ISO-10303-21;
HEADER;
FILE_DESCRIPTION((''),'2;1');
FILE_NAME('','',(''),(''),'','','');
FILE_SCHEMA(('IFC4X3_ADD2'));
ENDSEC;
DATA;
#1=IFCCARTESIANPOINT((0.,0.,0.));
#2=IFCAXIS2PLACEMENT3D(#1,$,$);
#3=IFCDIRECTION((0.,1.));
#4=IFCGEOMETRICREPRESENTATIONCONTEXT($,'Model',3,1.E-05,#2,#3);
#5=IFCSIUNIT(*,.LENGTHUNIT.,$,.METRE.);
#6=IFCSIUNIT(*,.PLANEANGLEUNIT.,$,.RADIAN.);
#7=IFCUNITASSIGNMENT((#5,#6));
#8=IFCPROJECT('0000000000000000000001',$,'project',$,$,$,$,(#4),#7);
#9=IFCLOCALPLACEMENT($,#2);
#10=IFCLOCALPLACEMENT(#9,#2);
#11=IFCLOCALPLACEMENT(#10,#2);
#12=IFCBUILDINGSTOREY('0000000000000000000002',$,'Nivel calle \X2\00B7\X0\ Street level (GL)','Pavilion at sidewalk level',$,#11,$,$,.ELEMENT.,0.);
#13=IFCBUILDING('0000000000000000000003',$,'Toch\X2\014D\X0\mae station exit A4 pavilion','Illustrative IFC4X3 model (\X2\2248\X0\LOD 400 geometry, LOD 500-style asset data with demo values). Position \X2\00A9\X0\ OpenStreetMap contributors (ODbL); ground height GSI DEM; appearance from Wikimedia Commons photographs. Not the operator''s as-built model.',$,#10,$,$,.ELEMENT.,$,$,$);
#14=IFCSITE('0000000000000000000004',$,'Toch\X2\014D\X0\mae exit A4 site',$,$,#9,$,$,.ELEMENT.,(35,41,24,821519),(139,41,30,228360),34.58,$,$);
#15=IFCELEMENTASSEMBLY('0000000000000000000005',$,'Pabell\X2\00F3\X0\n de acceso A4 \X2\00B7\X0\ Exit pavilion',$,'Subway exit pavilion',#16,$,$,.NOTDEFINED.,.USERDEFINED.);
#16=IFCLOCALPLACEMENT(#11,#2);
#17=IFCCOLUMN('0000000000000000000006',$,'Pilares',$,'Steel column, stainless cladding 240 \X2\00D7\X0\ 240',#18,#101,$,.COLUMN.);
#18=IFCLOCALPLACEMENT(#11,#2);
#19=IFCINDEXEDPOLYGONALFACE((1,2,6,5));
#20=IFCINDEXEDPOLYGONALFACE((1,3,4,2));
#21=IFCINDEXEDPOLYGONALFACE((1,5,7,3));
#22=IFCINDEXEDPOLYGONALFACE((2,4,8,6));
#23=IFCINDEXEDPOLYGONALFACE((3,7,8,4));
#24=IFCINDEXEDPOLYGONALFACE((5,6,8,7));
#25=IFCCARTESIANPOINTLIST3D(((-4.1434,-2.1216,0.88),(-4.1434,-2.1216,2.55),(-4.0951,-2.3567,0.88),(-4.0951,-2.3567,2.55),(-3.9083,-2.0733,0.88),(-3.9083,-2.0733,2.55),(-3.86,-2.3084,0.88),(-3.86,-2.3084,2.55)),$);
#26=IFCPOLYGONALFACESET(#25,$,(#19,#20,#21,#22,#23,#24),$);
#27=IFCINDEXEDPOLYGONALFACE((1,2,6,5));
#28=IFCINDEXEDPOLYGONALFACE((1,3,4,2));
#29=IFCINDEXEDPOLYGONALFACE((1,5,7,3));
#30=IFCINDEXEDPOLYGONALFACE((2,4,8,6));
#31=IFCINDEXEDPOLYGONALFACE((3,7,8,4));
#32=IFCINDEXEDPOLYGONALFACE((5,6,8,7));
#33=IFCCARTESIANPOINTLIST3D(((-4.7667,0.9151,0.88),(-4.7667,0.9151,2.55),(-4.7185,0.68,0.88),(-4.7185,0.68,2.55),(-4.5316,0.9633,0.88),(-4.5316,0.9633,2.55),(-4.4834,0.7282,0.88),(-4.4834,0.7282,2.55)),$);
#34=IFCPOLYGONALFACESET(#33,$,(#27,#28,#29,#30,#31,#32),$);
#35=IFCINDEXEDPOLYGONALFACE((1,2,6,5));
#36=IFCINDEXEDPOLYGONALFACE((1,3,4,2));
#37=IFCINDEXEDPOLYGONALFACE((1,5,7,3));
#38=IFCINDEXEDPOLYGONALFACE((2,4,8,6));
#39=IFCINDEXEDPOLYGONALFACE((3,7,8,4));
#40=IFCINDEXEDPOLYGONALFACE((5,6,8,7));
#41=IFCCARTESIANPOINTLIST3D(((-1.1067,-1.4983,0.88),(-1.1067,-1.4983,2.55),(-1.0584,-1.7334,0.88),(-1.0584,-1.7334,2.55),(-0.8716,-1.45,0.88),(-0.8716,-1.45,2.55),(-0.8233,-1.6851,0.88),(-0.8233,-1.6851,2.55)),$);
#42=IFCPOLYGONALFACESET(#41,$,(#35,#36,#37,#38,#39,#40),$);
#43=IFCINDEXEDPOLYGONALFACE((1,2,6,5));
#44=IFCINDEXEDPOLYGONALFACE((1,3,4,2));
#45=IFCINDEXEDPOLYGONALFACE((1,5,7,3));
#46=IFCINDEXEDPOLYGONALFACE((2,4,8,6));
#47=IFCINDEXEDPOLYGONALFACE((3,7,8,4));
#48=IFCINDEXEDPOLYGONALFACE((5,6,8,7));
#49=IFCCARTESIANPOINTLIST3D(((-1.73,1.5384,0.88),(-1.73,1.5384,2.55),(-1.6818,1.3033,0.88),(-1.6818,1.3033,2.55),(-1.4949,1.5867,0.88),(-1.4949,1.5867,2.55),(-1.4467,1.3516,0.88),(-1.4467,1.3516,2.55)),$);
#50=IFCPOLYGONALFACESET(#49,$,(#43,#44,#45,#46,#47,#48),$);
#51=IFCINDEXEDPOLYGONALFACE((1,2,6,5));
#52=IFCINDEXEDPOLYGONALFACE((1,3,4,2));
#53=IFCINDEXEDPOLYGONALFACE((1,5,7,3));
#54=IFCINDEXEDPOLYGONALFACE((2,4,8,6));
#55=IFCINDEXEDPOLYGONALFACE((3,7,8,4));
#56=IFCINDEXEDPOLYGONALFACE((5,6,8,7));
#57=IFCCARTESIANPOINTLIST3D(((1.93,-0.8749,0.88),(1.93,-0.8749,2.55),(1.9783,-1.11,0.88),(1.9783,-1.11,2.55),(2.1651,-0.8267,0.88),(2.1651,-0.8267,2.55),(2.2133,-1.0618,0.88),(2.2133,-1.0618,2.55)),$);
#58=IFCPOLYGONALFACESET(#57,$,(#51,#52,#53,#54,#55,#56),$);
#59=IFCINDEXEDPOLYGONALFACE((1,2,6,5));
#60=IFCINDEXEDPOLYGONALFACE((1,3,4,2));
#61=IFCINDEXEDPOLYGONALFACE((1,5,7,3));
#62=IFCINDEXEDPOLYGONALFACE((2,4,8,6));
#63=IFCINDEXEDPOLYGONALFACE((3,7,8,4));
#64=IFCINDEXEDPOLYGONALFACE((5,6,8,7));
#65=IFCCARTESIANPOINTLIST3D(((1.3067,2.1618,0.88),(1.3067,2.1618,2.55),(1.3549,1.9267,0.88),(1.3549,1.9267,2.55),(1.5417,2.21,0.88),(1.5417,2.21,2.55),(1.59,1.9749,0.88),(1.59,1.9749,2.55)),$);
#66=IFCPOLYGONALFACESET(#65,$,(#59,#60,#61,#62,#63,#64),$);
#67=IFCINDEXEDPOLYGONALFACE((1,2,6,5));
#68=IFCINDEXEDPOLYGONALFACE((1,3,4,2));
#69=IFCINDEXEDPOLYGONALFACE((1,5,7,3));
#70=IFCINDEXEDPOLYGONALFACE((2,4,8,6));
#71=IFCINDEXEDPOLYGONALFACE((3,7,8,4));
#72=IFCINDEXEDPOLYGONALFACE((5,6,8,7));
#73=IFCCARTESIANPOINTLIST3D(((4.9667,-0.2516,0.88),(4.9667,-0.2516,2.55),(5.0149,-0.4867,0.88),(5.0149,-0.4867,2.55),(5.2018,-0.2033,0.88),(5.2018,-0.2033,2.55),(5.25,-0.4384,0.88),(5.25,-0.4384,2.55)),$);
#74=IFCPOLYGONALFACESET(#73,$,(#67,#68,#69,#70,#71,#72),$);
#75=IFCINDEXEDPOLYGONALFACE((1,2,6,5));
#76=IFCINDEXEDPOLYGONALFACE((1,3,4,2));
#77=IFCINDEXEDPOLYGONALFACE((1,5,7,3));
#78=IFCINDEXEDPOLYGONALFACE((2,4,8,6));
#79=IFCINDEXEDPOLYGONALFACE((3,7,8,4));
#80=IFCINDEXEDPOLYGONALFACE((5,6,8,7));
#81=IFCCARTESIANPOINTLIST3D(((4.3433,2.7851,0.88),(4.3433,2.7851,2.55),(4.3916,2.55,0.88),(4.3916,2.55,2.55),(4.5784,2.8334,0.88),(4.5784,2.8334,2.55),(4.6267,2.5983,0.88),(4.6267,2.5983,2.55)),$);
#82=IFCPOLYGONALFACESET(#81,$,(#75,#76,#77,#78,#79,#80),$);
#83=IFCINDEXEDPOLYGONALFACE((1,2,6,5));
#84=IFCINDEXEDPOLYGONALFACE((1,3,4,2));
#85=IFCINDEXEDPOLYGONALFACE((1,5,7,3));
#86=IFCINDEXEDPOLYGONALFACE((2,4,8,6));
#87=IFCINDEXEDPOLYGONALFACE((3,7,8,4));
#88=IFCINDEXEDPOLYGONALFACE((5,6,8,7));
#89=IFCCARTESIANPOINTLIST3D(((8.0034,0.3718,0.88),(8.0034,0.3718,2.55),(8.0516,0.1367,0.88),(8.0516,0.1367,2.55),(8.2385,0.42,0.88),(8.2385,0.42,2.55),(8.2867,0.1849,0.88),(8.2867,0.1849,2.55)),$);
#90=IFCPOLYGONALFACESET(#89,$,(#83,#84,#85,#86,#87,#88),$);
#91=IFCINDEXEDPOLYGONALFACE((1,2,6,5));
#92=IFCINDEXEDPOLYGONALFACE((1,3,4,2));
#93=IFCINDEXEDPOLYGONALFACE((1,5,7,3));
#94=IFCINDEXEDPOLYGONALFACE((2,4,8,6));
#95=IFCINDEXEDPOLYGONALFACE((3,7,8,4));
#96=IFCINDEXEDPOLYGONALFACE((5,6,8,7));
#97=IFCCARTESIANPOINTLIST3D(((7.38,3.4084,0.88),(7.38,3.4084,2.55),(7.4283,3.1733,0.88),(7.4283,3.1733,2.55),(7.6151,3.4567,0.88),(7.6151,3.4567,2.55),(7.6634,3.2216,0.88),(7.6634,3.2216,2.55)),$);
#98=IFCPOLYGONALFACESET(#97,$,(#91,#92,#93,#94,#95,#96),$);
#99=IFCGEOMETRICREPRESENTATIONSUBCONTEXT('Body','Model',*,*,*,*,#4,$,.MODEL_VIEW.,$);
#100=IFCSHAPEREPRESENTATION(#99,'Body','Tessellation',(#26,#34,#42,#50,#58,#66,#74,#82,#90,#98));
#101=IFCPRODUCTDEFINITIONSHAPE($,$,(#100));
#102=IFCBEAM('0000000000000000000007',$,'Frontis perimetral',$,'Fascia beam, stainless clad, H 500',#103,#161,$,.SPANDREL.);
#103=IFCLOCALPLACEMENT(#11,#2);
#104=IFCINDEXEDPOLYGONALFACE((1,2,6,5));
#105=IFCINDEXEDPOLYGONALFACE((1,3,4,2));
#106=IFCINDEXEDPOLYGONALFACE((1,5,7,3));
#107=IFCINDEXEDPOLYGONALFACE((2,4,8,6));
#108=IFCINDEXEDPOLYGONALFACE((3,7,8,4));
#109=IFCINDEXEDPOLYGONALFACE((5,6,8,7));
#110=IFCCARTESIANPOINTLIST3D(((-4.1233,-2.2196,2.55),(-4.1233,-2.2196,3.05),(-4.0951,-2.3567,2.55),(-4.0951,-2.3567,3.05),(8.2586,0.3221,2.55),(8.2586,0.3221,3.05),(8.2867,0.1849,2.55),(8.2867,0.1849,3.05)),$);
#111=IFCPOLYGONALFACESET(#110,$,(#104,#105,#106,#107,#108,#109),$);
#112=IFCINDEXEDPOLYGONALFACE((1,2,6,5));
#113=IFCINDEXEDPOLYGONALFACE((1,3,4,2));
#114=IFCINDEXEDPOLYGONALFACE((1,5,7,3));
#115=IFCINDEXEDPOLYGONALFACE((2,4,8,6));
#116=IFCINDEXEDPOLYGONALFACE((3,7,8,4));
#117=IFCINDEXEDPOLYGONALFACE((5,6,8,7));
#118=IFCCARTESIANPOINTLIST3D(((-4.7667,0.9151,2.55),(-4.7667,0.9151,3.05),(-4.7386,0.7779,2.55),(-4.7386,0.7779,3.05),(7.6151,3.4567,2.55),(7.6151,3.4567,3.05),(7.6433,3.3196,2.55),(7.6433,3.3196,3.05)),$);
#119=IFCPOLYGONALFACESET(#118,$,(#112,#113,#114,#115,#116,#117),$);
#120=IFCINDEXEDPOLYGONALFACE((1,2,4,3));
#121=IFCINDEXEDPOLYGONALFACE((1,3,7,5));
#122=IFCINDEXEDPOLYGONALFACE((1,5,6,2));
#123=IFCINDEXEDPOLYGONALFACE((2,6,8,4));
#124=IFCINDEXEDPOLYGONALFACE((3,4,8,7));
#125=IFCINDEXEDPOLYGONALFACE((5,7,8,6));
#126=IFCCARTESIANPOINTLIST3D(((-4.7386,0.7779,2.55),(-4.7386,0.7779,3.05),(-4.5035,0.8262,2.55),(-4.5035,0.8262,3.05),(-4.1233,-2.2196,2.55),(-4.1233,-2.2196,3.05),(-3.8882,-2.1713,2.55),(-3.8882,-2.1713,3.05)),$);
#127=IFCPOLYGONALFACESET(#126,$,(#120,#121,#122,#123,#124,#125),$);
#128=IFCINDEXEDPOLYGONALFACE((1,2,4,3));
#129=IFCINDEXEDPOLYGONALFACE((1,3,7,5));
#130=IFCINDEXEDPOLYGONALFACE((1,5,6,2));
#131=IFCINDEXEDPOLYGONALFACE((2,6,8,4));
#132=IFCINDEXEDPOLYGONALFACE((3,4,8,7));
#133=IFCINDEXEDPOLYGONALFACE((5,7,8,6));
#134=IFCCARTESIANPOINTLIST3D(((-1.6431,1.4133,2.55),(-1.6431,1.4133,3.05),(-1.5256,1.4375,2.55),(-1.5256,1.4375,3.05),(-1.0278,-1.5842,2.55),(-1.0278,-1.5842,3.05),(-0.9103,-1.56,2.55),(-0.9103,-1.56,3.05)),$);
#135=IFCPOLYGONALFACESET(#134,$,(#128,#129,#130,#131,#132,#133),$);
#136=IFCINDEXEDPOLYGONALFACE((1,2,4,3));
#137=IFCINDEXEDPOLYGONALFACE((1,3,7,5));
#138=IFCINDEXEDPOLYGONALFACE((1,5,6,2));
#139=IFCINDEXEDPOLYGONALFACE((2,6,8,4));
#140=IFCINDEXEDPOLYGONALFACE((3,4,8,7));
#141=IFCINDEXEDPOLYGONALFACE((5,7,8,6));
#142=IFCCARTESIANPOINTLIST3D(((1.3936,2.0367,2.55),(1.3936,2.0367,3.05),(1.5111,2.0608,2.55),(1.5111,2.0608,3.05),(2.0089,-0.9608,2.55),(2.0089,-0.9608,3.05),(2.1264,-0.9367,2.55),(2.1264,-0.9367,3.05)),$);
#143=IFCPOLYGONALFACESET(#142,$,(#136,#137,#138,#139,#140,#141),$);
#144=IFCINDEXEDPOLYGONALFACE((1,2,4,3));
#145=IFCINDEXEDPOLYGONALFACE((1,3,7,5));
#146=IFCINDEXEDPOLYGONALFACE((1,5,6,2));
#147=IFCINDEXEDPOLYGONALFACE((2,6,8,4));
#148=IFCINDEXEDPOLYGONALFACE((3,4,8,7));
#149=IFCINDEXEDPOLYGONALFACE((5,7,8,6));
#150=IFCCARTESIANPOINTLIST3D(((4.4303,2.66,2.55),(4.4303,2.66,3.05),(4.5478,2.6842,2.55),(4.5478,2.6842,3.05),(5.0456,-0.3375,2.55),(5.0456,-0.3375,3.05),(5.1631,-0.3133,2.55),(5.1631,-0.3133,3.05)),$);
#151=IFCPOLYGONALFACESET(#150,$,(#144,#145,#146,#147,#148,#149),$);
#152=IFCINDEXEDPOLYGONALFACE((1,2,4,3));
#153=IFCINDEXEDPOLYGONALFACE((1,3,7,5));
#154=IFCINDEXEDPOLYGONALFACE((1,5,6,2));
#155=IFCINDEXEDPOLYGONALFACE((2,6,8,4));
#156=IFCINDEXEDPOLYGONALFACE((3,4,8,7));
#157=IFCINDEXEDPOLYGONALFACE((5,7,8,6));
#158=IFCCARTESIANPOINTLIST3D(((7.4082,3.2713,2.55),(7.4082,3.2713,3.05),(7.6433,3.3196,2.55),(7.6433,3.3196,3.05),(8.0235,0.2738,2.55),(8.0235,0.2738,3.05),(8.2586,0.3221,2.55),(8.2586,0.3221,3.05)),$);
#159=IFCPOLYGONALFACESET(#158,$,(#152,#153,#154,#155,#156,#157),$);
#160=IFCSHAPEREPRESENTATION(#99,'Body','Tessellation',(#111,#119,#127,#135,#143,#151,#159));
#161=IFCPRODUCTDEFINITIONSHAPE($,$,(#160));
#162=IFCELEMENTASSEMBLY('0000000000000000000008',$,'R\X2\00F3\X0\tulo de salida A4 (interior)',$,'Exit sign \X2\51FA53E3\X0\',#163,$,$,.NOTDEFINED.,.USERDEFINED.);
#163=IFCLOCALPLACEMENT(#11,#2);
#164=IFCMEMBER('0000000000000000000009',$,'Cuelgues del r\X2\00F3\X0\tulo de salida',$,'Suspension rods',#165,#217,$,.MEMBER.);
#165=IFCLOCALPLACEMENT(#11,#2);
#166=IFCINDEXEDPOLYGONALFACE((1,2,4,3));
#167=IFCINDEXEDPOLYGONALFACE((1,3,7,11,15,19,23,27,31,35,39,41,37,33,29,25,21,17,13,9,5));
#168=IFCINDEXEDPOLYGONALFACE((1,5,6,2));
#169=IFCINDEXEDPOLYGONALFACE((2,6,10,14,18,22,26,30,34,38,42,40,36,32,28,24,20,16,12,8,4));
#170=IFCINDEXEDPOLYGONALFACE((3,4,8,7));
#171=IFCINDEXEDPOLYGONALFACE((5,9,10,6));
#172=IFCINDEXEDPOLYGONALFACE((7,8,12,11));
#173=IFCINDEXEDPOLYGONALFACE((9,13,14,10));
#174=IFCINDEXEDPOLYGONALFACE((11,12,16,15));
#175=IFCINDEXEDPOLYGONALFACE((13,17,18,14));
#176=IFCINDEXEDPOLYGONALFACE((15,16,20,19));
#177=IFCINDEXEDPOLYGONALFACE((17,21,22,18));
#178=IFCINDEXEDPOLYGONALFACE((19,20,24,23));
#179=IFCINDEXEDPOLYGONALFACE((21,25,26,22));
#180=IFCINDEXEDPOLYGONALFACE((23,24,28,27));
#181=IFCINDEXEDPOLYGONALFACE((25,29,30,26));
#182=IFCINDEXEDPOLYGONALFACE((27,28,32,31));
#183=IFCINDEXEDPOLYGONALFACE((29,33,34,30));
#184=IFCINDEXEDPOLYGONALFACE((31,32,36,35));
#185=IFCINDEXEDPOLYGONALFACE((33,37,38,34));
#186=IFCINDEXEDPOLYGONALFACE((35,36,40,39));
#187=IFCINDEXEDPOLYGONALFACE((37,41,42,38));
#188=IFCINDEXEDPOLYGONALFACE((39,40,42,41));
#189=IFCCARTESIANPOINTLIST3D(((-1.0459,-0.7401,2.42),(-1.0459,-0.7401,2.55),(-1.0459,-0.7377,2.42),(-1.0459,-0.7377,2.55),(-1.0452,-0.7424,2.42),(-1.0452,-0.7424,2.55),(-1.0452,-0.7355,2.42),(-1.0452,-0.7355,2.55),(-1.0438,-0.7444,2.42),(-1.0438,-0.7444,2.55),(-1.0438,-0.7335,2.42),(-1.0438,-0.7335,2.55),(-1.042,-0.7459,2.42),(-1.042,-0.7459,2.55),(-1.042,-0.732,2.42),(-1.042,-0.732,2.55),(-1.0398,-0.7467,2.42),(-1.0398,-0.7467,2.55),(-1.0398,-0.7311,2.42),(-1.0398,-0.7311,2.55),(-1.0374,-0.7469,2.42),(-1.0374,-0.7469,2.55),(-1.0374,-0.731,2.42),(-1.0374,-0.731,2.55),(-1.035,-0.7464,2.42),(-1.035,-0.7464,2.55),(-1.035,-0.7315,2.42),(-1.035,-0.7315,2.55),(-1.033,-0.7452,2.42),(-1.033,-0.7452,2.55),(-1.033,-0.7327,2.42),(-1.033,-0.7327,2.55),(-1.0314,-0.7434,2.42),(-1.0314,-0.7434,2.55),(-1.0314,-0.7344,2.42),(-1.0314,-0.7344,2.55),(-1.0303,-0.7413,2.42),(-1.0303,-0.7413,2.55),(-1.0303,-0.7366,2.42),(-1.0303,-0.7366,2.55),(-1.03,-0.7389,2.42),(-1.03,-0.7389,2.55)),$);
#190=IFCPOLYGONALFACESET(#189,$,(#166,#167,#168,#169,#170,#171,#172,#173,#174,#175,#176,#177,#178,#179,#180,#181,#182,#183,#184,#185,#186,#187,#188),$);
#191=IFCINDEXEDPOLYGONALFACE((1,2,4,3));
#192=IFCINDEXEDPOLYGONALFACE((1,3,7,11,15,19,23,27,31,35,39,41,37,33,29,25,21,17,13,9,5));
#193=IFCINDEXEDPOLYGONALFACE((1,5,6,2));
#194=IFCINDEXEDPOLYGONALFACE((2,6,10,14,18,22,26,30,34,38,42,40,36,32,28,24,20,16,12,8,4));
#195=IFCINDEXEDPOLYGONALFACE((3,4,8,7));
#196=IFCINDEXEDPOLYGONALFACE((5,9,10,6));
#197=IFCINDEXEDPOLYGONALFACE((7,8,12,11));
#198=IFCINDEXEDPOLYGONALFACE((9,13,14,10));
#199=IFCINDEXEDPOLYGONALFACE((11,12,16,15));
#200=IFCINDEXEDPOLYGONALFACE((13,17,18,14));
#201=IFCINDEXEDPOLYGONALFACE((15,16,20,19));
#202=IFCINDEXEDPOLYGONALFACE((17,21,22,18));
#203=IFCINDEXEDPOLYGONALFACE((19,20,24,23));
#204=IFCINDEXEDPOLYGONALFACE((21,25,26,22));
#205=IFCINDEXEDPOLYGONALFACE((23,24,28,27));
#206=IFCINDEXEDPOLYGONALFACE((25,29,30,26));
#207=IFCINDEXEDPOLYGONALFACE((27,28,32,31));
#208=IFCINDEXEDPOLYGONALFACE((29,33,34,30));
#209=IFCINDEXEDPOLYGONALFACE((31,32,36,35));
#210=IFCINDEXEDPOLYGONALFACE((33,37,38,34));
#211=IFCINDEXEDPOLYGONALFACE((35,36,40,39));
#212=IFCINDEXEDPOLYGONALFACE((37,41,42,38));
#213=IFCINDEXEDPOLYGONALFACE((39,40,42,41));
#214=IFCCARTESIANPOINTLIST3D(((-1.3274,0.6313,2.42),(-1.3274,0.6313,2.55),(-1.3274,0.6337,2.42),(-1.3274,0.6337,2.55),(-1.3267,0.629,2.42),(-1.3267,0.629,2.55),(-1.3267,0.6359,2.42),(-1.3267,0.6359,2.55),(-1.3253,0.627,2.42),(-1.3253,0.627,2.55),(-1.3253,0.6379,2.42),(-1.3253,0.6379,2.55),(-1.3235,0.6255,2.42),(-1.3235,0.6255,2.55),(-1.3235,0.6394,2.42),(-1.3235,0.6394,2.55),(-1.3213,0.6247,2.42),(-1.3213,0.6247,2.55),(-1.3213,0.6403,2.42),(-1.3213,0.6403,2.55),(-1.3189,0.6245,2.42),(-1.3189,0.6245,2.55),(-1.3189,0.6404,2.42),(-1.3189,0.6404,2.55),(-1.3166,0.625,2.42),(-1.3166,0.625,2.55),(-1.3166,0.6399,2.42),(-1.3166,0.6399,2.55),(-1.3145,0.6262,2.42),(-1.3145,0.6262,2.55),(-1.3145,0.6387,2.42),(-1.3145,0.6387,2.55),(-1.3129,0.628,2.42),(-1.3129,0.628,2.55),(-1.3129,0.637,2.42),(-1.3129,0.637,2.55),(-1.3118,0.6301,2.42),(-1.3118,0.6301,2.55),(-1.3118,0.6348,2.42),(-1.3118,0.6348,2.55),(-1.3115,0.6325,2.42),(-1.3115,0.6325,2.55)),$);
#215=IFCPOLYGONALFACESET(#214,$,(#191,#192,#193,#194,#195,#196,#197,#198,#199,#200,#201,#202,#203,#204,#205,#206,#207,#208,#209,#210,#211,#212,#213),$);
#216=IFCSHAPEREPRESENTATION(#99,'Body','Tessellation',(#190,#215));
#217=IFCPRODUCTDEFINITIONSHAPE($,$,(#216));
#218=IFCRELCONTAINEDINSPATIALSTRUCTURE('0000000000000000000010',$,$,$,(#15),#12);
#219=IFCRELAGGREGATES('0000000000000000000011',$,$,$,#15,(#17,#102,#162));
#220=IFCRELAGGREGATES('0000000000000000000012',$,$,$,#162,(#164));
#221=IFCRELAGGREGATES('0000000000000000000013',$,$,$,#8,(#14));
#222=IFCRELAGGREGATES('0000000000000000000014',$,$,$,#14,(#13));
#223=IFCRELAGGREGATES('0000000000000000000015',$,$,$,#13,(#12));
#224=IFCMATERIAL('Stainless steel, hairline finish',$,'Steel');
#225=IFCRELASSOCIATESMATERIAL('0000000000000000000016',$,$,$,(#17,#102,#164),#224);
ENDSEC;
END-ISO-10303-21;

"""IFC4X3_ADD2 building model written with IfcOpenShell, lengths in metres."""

from ifc_helpers import new_model, si_unit, direction, frame, frame_2d, origin, origin_2d_with_axis, place, context, subcontext, project, spatial, rectangle, circle, extrude, material, element, aggregate, save


model = new_model("IFC4X3_ADD2")

# Units and contexts
model_context = context("Model", 3, precision=1e-05, world=origin(), true_north=direction((0.0, 1.0)))
body_context = subcontext(model_context, "Body", "Model", "MODEL_VIEW")
ifc_project = project(units=[si_unit("LENGTHUNIT", "METRE"), si_unit("PLANEANGLEUNIT", "RADIAN")], contexts=[model_context])

# Site, building, storey
site_placement = place(None, origin())
site = spatial("IfcSite", under=ifc_project, at=site_placement, Name="Tochōmae exit A4 site", CompositionType="ELEMENT", RefLatitude=(35, 41, 24, 821519), RefLongitude=(139, 41, 30, 228360), RefElevation=34.58)
building_placement = place(site_placement, origin())
building = spatial("IfcBuilding", under=site, at=building_placement, Name="Tochōmae station exit A4 pavilion", Description="Illustrative IFC4X3 model (≈LOD 400 geometry, LOD 500-style asset data with demo values). Position © OpenStreetMap contributors (ODbL); ground height GSI DEM; appearance from Wikimedia Commons photographs. Not the operator's as-built model.", CompositionType="ELEMENT")
storey_placement = place(building_placement, origin())
storey = spatial("IfcBuildingStorey", under=building, at=storey_placement, Name="Nivel calle · Street level (GL)", Description="Pavilion at sidewalk level", CompositionType="ELEMENT", Elevation=0.0)

# Element assemblies, column, beam, member
assembly_1_placement = place(building_placement, origin())
assembly_1 = element("IfcElementAssembly", 1, at=assembly_1_placement, inside=storey, Name="Pabellón de acceso A4 · Exit pavilion", ObjectType="Subway exit pavilion", AssemblyPlace="NOTDEFINED", PredefinedType="USERDEFINED")
ifc_material_1 = material(Name="Stainless steel, hairline finish", Category="Steel")
column_placement = place(building_placement, origin())
column = element("IfcColumn", 2, at=column_placement, material=ifc_material_1, Name="Pilares", ObjectType="Steel column, stainless cladding 240 × 240", PredefinedType="COLUMN", context=body_context, shape_type="SweptSolid", body=[
    extrude(rectangle(XDim=0.24, YDim=0.24, at=frame_2d((0.0, 0.0), x_axis=(0.979575, 0.201078))), frame((-4.0017, -2.215, 0.88)), (0.0, 0.0, 1.0), 1.67),
    extrude(rectangle(XDim=0.24, YDim=0.24, at=frame_2d((0.0, 0.0), x_axis=(0.979575, 0.201078))), frame((-4.625, 0.8217, 0.88)), (0.0, 0.0, 1.0), 1.67),
    extrude(rectangle(XDim=0.24, YDim=0.24, at=frame_2d((0.0, 0.0), x_axis=(0.979575, 0.201078))), frame((-0.965, -1.5917, 0.88)), (0.0, 0.0, 1.0), 1.67),
    extrude(rectangle(XDim=0.24, YDim=0.24, at=frame_2d((0.0, 0.0), x_axis=(0.979575, 0.201078))), frame((-1.5884, 1.445, 0.88)), (0.0, 0.0, 1.0), 1.67),
    extrude(rectangle(XDim=0.24, YDim=0.24, at=frame_2d((0.0, 0.0), x_axis=(0.979575, 0.201078))), frame((2.0717, -0.9683, 0.88)), (0.0, 0.0, 1.0), 1.67),
    extrude(rectangle(XDim=0.24, YDim=0.24, at=frame_2d((0.0, 0.0), x_axis=(0.979575, 0.201078))), frame((1.4483, 2.0683, 0.88)), (0.0, 0.0, 1.0), 1.67),
    extrude(rectangle(XDim=0.24, YDim=0.24, at=frame_2d((0.0, 0.0), x_axis=(0.979575, 0.201078))), frame((5.1084, -0.345, 0.88)), (0.0, 0.0, 1.0), 1.67),
    extrude(rectangle(XDim=0.24, YDim=0.24, at=frame_2d((0.0, 0.0), x_axis=(0.979575, 0.201078))), frame((4.485, 2.6917, 0.88)), (0.0, 0.0, 1.0), 1.67),
    extrude(rectangle(XDim=0.24, YDim=0.24, at=frame_2d((0.0, 0.0), x_axis=(0.979575, 0.201078))), frame((8.145, 0.2783, 0.88)), (0.0, 0.0, 1.0), 1.67),
    extrude(rectangle(XDim=0.24, YDim=0.24, at=frame_2d((0.0, 0.0), x_axis=(0.979575, 0.201078))), frame((7.5217, 3.315, 0.88)), (0.0, 0.0, 1.0), 1.67),
])
beam_placement = place(building_placement, origin())
beam = element("IfcBeam", 3, at=beam_placement, material=ifc_material_1, Name="Frontis perimetral", ObjectType="Fascia beam, stainless clad, H 500", PredefinedType="SPANDREL", context=body_context, shape_type="SweptSolid", body=[
    extrude(rectangle(XDim=12.64, YDim=0.14, at=frame_2d((0.0, 0.0), x_axis=(0.979575, 0.201078))), frame((2.0817, -1.0173, 2.55)), (0.0, 0.0, 1.0), 0.5),
    extrude(rectangle(XDim=12.64, YDim=0.14, at=frame_2d((0.0, 0.0), x_axis=(0.979575, 0.201078))), frame((1.4383, 2.1173, 2.55)), (0.0, 0.0, 1.0), 0.5),
    extrude(rectangle(XDim=0.24, YDim=3.06, at=frame_2d((0.0, 0.0), x_axis=(0.979575, 0.201078))), frame((-4.3134, -0.6967, 2.55)), (0.0, 0.0, 1.0), 0.5),
    extrude(rectangle(XDim=0.12, YDim=3.06, at=frame_2d((0.0, 0.0), x_axis=(0.979575, 0.201078))), frame((-1.2767, -0.0733, 2.55)), (0.0, 0.0, 1.0), 0.5),
    extrude(rectangle(XDim=0.12, YDim=3.06, at=frame_2d((0.0, 0.0), x_axis=(0.979575, 0.201078))), frame((1.76, 0.55, 2.55)), (0.0, 0.0, 1.0), 0.5),
    extrude(rectangle(XDim=0.12, YDim=3.06, at=frame_2d((0.0, 0.0), x_axis=(0.979575, 0.201078))), frame((4.7967, 1.1733, 2.55)), (0.0, 0.0, 1.0), 0.5),
    extrude(rectangle(XDim=0.24, YDim=3.06, at=frame_2d((0.0, 0.0), x_axis=(0.979575, 0.201078))), frame((7.8334, 1.7967, 2.55)), (0.0, 0.0, 1.0), 0.5),
])
assembly_2_placement = place(building_placement, origin())
assembly_2 = element("IfcElementAssembly", 4, at=assembly_2_placement, Name="Rótulo de salida A4 (interior)", ObjectType="Exit sign 出口", AssemblyPlace="NOTDEFINED", PredefinedType="USERDEFINED")
member_1_placement = place(building_placement, origin())
member_1 = element("IfcMember", 5, at=member_1_placement, material=ifc_material_1, Name="Cuelgues del rótulo de salida", ObjectType="Suspension rods", PredefinedType="MEMBER", context=body_context, shape_type="SweptSolid", body=[
    extrude(circle(Radius=0.008, at=origin_2d_with_axis()), frame((-1.038, -0.7389, 2.42)), (0.0, 0.0, 1.0), 0.13),
    extrude(circle(Radius=0.008, at=origin_2d_with_axis()), frame((-1.3195, 0.6325, 2.42)), (0.0, 0.0, 1.0), 0.13),
])
aggregate(assembly_1, [column, beam, assembly_2])
aggregate(assembly_2, [member_1])

save(model, "model.ifc")
